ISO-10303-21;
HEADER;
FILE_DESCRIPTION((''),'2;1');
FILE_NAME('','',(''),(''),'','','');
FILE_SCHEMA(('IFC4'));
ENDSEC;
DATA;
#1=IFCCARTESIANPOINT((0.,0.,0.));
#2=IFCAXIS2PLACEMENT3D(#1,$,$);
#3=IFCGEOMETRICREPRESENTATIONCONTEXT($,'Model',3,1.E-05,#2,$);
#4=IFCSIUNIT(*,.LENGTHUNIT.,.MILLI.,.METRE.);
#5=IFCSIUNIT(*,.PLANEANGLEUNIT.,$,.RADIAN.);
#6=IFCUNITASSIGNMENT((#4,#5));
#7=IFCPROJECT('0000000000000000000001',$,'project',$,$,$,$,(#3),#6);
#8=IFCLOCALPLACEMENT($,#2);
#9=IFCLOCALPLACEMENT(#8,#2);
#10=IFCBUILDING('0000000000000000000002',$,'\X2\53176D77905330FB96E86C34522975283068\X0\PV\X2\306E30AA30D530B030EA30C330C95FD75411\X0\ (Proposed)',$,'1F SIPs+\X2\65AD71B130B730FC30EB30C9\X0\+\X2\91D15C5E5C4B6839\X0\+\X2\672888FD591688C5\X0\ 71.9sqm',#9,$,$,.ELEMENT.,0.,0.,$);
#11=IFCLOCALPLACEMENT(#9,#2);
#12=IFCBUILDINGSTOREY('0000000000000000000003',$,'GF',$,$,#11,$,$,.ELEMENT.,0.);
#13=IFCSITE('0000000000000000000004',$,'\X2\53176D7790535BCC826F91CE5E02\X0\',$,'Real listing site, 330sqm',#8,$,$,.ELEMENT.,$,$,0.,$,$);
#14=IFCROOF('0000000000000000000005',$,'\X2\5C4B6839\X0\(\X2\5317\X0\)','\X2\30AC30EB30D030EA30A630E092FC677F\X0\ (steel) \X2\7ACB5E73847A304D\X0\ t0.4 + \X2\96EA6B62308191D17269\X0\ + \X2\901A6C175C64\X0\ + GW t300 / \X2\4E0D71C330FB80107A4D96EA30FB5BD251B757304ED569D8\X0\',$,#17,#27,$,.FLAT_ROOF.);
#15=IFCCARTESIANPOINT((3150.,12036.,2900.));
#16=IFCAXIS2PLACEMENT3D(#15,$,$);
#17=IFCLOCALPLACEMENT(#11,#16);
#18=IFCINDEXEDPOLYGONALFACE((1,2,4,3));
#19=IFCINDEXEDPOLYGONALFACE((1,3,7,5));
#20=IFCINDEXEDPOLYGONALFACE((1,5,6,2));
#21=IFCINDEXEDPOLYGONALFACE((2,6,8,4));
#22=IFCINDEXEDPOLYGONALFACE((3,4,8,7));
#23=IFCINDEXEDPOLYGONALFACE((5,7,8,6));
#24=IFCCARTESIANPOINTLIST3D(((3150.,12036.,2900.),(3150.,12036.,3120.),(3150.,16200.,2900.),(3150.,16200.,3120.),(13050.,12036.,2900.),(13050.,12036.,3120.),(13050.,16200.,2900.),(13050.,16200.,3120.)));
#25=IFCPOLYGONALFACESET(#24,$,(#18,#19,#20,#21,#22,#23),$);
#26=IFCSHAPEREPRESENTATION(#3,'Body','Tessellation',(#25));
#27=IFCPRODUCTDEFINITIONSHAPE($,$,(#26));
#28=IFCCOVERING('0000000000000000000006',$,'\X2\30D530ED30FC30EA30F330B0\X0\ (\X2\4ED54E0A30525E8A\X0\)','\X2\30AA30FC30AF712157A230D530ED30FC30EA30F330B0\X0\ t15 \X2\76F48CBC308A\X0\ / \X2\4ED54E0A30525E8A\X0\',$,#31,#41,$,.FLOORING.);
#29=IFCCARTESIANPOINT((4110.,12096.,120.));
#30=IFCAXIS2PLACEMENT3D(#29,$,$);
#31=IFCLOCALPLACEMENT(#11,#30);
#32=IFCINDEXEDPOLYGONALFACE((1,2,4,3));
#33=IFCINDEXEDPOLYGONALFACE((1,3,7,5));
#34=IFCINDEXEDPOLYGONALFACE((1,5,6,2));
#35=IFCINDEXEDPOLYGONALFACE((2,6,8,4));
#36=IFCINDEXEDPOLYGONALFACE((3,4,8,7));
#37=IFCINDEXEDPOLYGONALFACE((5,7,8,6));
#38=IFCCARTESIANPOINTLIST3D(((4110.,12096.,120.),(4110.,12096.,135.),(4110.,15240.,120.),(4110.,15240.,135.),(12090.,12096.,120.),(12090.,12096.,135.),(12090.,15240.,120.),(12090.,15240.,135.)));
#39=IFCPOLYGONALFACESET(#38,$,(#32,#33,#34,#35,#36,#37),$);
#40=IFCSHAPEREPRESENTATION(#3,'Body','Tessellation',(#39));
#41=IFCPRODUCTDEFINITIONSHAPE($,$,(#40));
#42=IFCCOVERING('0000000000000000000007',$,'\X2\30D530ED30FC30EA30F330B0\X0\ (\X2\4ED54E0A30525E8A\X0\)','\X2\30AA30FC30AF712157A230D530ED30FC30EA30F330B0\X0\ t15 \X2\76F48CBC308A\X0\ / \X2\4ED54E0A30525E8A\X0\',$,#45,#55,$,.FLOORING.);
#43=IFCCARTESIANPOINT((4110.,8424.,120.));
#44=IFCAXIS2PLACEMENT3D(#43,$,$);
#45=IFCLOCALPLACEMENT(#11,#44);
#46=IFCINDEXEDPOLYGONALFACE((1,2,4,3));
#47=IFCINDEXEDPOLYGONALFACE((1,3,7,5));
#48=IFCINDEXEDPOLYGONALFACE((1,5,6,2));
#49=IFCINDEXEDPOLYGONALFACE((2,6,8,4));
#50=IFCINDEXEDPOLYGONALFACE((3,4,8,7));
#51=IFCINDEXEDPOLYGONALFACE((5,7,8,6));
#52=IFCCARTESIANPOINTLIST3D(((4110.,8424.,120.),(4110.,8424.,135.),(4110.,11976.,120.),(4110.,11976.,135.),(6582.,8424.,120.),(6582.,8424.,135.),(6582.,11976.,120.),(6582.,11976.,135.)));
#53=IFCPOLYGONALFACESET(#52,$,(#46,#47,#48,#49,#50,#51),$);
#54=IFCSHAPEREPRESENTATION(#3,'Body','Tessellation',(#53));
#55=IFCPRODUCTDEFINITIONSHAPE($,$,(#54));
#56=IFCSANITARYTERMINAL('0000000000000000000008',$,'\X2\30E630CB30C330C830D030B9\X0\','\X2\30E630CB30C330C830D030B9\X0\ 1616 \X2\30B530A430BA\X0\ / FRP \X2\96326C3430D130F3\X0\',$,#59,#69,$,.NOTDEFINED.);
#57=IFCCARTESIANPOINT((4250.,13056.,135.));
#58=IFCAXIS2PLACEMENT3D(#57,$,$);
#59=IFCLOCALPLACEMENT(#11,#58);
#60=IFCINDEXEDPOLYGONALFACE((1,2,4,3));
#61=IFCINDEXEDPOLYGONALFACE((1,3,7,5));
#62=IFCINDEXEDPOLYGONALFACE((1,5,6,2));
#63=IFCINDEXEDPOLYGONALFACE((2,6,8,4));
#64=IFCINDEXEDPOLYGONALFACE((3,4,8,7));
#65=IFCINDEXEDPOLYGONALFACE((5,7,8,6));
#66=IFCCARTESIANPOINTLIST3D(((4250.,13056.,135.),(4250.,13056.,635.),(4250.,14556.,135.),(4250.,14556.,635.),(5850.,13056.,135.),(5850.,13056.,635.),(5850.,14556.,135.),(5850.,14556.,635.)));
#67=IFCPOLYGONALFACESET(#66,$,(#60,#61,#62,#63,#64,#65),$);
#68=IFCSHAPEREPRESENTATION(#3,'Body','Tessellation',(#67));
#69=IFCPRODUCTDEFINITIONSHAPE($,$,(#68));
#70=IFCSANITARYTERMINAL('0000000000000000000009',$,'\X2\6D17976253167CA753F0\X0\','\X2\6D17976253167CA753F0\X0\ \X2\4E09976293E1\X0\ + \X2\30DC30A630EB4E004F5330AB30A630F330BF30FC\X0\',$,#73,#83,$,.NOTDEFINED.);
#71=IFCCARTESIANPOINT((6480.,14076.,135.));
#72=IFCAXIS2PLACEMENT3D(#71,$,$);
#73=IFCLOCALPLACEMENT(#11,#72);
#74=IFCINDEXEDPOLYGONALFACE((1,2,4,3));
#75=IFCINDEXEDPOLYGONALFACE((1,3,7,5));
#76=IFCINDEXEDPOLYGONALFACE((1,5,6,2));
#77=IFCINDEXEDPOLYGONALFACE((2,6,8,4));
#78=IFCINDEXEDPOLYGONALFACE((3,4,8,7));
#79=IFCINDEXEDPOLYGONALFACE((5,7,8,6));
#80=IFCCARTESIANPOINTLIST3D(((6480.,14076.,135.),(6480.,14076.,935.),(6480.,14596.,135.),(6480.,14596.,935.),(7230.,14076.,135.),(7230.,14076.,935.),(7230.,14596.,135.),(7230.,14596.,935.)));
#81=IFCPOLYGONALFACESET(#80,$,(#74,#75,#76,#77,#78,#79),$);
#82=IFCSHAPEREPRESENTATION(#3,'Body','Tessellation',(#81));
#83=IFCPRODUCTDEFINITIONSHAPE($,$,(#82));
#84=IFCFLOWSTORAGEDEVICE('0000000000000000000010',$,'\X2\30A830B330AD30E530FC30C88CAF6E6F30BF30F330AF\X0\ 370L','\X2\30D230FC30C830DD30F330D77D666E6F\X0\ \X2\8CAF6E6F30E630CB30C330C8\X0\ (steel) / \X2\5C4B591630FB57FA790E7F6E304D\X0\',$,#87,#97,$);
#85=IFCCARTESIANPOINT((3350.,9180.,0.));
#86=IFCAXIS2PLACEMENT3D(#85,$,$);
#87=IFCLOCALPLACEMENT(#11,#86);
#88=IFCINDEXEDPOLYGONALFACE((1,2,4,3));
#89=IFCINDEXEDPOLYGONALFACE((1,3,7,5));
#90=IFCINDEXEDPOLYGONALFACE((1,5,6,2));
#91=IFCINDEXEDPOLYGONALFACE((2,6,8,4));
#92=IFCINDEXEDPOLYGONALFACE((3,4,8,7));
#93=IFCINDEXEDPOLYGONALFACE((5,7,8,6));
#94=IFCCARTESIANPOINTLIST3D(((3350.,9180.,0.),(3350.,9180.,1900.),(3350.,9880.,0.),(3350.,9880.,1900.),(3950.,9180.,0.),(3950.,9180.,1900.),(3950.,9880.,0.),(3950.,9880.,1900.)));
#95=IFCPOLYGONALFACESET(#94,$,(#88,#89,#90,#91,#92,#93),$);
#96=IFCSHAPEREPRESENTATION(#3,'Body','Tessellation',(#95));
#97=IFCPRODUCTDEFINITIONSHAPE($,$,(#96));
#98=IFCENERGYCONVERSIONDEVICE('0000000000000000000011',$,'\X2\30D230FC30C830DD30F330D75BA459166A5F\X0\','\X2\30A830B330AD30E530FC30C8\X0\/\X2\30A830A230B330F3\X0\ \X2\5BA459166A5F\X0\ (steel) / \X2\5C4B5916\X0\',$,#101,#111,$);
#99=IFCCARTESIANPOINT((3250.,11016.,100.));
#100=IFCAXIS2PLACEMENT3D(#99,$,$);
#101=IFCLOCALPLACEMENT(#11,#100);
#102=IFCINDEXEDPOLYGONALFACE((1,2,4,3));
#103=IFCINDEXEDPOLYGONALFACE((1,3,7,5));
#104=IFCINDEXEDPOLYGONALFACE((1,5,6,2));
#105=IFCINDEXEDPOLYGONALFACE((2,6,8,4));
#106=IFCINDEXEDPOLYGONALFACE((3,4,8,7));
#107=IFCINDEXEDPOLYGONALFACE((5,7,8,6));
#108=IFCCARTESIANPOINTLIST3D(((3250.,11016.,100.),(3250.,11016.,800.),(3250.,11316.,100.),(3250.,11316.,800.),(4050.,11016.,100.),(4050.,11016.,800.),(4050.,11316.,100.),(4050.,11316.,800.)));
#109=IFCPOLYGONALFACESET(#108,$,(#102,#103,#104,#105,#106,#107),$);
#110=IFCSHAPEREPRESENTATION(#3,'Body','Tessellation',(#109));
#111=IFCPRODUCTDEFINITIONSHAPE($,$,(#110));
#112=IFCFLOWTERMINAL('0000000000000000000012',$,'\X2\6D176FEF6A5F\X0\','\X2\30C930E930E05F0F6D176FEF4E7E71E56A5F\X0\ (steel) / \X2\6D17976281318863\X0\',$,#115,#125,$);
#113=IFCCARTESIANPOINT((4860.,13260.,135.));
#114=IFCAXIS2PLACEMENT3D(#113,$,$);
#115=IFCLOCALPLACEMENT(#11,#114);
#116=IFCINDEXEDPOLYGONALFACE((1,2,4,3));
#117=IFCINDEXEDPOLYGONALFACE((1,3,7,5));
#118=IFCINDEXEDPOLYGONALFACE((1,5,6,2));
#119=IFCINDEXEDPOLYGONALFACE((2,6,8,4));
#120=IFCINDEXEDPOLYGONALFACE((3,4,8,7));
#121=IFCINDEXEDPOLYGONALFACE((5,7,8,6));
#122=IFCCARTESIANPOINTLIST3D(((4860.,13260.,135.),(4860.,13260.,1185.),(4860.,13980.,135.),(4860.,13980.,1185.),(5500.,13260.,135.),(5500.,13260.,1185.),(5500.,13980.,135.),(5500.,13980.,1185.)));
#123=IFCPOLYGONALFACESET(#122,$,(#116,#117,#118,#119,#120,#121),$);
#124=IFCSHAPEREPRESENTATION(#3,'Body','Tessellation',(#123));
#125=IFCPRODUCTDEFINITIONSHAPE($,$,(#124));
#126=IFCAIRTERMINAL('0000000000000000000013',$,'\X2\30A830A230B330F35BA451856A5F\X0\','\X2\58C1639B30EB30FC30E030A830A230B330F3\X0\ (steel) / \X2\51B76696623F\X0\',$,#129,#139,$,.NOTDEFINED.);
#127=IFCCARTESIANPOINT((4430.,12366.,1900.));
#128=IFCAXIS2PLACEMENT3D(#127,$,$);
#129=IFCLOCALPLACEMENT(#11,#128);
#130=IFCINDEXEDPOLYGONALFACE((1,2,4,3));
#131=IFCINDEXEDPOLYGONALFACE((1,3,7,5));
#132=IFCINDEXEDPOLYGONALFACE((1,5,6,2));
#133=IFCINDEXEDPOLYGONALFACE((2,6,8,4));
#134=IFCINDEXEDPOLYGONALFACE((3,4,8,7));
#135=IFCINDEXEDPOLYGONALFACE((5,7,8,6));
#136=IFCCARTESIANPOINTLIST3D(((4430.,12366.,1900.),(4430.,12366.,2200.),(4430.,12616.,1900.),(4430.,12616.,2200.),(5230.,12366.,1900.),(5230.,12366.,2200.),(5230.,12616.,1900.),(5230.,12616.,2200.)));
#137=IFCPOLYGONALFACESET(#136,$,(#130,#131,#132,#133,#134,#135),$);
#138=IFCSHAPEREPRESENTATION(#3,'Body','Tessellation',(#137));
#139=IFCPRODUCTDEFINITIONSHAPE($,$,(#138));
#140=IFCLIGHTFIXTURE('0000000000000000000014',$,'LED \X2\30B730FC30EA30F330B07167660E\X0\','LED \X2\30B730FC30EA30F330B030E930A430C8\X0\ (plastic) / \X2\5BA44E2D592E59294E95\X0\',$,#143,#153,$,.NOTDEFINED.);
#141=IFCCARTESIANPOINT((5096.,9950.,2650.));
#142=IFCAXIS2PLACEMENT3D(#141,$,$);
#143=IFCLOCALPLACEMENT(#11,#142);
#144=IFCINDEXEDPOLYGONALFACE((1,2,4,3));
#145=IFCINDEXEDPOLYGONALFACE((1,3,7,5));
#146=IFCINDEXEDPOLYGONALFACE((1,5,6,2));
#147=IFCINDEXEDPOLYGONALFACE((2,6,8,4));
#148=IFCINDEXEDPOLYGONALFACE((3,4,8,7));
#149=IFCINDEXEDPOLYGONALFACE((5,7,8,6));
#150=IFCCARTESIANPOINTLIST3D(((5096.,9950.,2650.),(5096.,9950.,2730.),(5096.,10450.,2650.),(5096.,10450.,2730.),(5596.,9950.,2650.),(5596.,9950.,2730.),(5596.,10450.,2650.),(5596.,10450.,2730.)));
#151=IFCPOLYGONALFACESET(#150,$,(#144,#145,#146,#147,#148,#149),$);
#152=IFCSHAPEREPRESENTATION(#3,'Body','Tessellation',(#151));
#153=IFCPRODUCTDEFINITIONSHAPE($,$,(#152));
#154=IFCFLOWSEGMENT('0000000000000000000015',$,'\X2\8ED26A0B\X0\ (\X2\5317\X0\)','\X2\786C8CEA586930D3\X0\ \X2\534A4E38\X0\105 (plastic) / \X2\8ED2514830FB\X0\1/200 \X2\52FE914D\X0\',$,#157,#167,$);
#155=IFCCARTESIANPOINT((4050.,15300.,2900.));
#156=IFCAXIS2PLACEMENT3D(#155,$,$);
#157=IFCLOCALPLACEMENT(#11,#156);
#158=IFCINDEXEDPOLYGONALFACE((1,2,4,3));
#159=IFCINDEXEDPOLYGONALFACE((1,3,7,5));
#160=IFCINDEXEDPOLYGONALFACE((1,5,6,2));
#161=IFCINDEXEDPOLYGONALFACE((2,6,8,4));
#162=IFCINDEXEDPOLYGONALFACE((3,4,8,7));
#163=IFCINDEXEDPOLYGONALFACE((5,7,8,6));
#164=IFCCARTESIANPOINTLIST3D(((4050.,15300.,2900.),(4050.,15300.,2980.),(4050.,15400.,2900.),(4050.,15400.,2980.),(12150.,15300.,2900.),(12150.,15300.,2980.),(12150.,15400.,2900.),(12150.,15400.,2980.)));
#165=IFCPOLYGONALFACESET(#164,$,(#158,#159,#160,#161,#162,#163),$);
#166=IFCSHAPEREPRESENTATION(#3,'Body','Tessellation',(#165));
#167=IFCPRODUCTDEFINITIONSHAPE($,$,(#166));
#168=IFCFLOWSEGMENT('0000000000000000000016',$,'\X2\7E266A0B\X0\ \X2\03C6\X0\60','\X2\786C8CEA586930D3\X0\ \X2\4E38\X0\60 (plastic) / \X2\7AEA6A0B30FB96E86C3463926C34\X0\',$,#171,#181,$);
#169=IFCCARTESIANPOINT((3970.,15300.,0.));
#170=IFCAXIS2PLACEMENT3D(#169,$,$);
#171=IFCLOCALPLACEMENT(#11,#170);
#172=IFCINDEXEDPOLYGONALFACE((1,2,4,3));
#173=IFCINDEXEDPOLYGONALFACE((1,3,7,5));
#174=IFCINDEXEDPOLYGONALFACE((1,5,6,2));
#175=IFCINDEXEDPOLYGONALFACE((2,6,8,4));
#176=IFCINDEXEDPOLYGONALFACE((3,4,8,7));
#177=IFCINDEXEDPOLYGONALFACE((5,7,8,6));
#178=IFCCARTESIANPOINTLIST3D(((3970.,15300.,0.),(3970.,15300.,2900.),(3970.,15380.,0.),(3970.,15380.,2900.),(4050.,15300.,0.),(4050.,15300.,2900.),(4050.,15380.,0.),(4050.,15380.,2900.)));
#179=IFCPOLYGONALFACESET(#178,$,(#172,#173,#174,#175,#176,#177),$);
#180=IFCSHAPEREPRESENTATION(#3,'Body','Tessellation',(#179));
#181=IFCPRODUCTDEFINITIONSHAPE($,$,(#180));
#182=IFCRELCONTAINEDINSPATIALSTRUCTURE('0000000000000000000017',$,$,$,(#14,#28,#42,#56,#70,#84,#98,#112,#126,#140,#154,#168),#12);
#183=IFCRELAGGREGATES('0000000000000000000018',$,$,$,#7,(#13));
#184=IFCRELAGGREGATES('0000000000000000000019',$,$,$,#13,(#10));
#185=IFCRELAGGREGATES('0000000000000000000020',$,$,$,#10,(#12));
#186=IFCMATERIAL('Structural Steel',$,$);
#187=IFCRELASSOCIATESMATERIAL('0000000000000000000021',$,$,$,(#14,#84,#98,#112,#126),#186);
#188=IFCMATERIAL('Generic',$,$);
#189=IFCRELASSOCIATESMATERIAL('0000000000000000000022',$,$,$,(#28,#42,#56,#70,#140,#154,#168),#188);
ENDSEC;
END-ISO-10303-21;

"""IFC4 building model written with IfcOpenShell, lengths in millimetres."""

from ifc_helpers import new_model, si_unit, frame, frame_2d, origin, place, context, project, spatial, rectangle, extrude, material, element, save


model = new_model("IFC4")

# Units and contexts
model_context = context("Model", 3, precision=1e-05, world=origin())
ifc_project = project(units=[si_unit("LENGTHUNIT", "METRE", prefix="MILLI"), si_unit("PLANEANGLEUNIT", "RADIAN")], contexts=[model_context])

# Site, building, storey
site_placement = place(None, origin())
site = spatial("IfcSite", under=ifc_project, at=site_placement, Name="北海道富良野市", ObjectType="Real listing site, 330sqm", CompositionType="ELEMENT", RefElevation=0.0)
building_placement = place(site_placement, origin())
building = spatial("IfcBuilding", under=site, at=building_placement, Name="北海道・雨水利用とPVのオフグリッド志向 (Proposed)", ObjectType="1F SIPs+断熱シールド+金属屋根+木製外装 71.9sqm", CompositionType="ELEMENT", ElevationOfRefHeight=0.0, ElevationOfTerrain=0.0)
storey_placement = place(building_placement, origin())
storey = spatial("IfcBuildingStorey", under=building, at=storey_placement, Name="GF", CompositionType="ELEMENT", Elevation=0.0)

# Roof
ifc_material_1 = material(Name="Structural Steel")
roof_placement = place(storey_placement, frame((3150.0, 12036.0, 2900.0)))
element("IfcRoof", 1, at=roof_placement, inside=storey, material=ifc_material_1, Name="屋根(北)", Description="ガルバリウム鋼板 (steel) 立平葺き t0.4 + 雪止め金物 + 通気層 + GW t300 / 不燃・耐積雪・寒冷地仕様", PredefinedType="FLAT_ROOF", context=model_context, shape_type="SweptSolid", body=[
    extrude(rectangle(XDim=9900.0, YDim=4164.0, at=frame_2d((4950.0, 2082.0))), frame((3150.0, 12036.0, 2900.0)), (0.0, 0.0, 1.0), 220.0),
])

# Coverings
ifc_material_2 = material(Name="Generic")
covering_1_placement = place(storey_placement, frame((4110.0, 12096.0, 120.0)))
element("IfcCovering", 2, at=covering_1_placement, inside=storey, material=ifc_material_2, Name="フローリング (仕上げ床)", Description="オーク無垢フローリング t15 直貼り / 仕上げ床", PredefinedType="FLOORING", context=model_context, shape_type="SweptSolid", body=[
    extrude(rectangle(XDim=7980.0, YDim=3144.0, at=frame_2d((3990.0, 1572.0))), frame((4110.0, 12096.0, 120.0)), (0.0, 0.0, 1.0), 15.0),
])
covering_2_placement = place(storey_placement, frame((4110.0, 8424.0, 120.0)))
element("IfcCovering", 3, at=covering_2_placement, inside=storey, material=ifc_material_2, Name="フローリング (仕上げ床)", Description="オーク無垢フローリング t15 直貼り / 仕上げ床", PredefinedType="FLOORING", context=model_context, shape_type="SweptSolid", body=[
    extrude(rectangle(XDim=2472.0, YDim=3552.0, at=frame_2d((1236.0, 1776.0))), frame((4110.0, 8424.0, 120.0)), (0.0, 0.0, 1.0), 15.0),
])

# Sanitary terminals
sanitary_terminal_1_placement = place(storey_placement, frame((4250.0, 13056.0, 135.0)))
element("IfcSanitaryTerminal", 4, at=sanitary_terminal_1_placement, inside=storey, material=ifc_material_2, Name="ユニットバス", Description="ユニットバス 1616 サイズ / FRP 防水パン", PredefinedType="NOTDEFINED", context=model_context, shape_type="SweptSolid", body=[
    extrude(rectangle(XDim=1600.0, YDim=1500.0, at=frame_2d((800.0, 750.0))), frame((4250.0, 13056.0, 135.0)), (0.0, 0.0, 1.0), 500.0),
])
sanitary_terminal_2_placement = place(storey_placement, frame((6480.0, 14076.0, 135.0)))
element("IfcSanitaryTerminal", 5, at=sanitary_terminal_2_placement, inside=storey, material=ifc_material_2, Name="洗面化粧台", Description="洗面化粧台 三面鏡 + ボウル一体カウンター", PredefinedType="NOTDEFINED", context=model_context, shape_type="SweptSolid", body=[
    extrude(rectangle(XDim=750.0, YDim=520.0, at=frame_2d((375.0, 260.0))), frame((6480.0, 14076.0, 135.0)), (0.0, 0.0, 1.0), 800.0),
])

# Flow storage device
flow_storage_device_placement = place(storey_placement, frame((3350.0, 9180.0, 0.0)))
element("IfcFlowStorageDevice", 6, at=flow_storage_device_placement, inside=storey, material=ifc_material_1, Name="エコキュート貯湯タンク 370L", Description="ヒートポンプ給湯 貯湯ユニット (steel) / 屋外・基礎置き", context=model_context, shape_type="SweptSolid", body=[
    extrude(rectangle(XDim=600.0, YDim=700.0, at=frame_2d((300.0, 350.0))), frame((3350.0, 9180.0, 0.0)), (0.0, 0.0, 1.0), 1900.0),
])

# Energy conversion device
energy_conversion_device_placement = place(storey_placement, frame((3250.0, 11016.0, 100.0)))
element("IfcEnergyConversionDevice", 7, at=energy_conversion_device_placement, inside=storey, material=ifc_material_1, Name="ヒートポンプ室外機", Description="エコキュート/エアコン 室外機 (steel) / 屋外", context=model_context, shape_type="SweptSolid", body=[
    extrude(rectangle(XDim=800.0, YDim=300.0, at=frame_2d((400.0, 150.0))), frame((3250.0, 11016.0, 100.0)), (0.0, 0.0, 1.0), 700.0),
])

# Flow terminal
flow_terminal_placement = place(storey_placement, frame((4860.0, 13260.0, 135.0)))
element("IfcFlowTerminal", 8, at=flow_terminal_placement, inside=storey, material=ifc_material_1, Name="洗濯機", Description="ドラム式洗濯乾燥機 (steel) / 洗面脱衣", context=model_context, shape_type="SweptSolid", body=[
    extrude(rectangle(XDim=640.0, YDim=720.0, at=frame_2d((320.0, 360.0))), frame((4860.0, 13260.0, 135.0)), (0.0, 0.0, 1.0), 1050.0),
])

# Air terminal
air_terminal_placement = place(storey_placement, frame((4430.0, 12366.0, 1900.0)))
element("IfcAirTerminal", 9, at=air_terminal_placement, inside=storey, material=ifc_material_1, Name="エアコン室内機", Description="壁掛ルームエアコン (steel) / 冷暖房", PredefinedType="NOTDEFINED", context=model_context, shape_type="SweptSolid", body=[
    extrude(rectangle(XDim=800.0, YDim=250.0, at=frame_2d((400.0, 125.0))), frame((4430.0, 12366.0, 1900.0)), (0.0, 0.0, 1.0), 300.0),
])

# Light fixture
light_fixture_placement = place(storey_placement, frame((5096.0, 9950.0, 2650.0)))
element("IfcLightFixture", 10, at=light_fixture_placement, inside=storey, material=ifc_material_2, Name="LED シーリング照明", Description="LED シーリングライト (plastic) / 室中央天井", PredefinedType="NOTDEFINED", context=model_context, shape_type="SweptSolid", body=[
    extrude(rectangle(XDim=500.0, YDim=500.0, at=frame_2d((250.0, 250.0))), frame((5096.0, 9950.0, 2650.0)), (0.0, 0.0, 1.0), 80.0),
])

# Flow segments
flow_segment_1_placement = place(storey_placement, frame((4050.0, 15300.0, 2900.0)))
element("IfcFlowSegment", 11, at=flow_segment_1_placement, inside=storey, material=ifc_material_2, Name="軒樋 (北)", Description="硬質塩ビ 半丸105 (plastic) / 軒先・1/200 勾配", context=model_context, shape_type="SweptSolid", body=[
    extrude(rectangle(XDim=8100.0, YDim=100.0, at=frame_2d((4050.0, 50.0))), frame((4050.0, 15300.0, 2900.0)), (0.0, 0.0, 1.0), 80.0),
])
flow_segment_2_placement = place(storey_placement, frame((3970.0, 15300.0, 0.0)))
element("IfcFlowSegment", 12, at=flow_segment_2_placement, inside=storey, material=ifc_material_2, Name="縦樋 φ60", Description="硬質塩ビ 丸60 (plastic) / 竪樋・雨水排水", context=model_context, shape_type="SweptSolid", body=[
    extrude(rectangle(XDim=80.0, YDim=80.0, at=frame_2d((40.0, 40.0))), frame((3970.0, 15300.0, 0.0)), (0.0, 0.0, 1.0), 2900.0),
])

save(model, "model.ifc")
